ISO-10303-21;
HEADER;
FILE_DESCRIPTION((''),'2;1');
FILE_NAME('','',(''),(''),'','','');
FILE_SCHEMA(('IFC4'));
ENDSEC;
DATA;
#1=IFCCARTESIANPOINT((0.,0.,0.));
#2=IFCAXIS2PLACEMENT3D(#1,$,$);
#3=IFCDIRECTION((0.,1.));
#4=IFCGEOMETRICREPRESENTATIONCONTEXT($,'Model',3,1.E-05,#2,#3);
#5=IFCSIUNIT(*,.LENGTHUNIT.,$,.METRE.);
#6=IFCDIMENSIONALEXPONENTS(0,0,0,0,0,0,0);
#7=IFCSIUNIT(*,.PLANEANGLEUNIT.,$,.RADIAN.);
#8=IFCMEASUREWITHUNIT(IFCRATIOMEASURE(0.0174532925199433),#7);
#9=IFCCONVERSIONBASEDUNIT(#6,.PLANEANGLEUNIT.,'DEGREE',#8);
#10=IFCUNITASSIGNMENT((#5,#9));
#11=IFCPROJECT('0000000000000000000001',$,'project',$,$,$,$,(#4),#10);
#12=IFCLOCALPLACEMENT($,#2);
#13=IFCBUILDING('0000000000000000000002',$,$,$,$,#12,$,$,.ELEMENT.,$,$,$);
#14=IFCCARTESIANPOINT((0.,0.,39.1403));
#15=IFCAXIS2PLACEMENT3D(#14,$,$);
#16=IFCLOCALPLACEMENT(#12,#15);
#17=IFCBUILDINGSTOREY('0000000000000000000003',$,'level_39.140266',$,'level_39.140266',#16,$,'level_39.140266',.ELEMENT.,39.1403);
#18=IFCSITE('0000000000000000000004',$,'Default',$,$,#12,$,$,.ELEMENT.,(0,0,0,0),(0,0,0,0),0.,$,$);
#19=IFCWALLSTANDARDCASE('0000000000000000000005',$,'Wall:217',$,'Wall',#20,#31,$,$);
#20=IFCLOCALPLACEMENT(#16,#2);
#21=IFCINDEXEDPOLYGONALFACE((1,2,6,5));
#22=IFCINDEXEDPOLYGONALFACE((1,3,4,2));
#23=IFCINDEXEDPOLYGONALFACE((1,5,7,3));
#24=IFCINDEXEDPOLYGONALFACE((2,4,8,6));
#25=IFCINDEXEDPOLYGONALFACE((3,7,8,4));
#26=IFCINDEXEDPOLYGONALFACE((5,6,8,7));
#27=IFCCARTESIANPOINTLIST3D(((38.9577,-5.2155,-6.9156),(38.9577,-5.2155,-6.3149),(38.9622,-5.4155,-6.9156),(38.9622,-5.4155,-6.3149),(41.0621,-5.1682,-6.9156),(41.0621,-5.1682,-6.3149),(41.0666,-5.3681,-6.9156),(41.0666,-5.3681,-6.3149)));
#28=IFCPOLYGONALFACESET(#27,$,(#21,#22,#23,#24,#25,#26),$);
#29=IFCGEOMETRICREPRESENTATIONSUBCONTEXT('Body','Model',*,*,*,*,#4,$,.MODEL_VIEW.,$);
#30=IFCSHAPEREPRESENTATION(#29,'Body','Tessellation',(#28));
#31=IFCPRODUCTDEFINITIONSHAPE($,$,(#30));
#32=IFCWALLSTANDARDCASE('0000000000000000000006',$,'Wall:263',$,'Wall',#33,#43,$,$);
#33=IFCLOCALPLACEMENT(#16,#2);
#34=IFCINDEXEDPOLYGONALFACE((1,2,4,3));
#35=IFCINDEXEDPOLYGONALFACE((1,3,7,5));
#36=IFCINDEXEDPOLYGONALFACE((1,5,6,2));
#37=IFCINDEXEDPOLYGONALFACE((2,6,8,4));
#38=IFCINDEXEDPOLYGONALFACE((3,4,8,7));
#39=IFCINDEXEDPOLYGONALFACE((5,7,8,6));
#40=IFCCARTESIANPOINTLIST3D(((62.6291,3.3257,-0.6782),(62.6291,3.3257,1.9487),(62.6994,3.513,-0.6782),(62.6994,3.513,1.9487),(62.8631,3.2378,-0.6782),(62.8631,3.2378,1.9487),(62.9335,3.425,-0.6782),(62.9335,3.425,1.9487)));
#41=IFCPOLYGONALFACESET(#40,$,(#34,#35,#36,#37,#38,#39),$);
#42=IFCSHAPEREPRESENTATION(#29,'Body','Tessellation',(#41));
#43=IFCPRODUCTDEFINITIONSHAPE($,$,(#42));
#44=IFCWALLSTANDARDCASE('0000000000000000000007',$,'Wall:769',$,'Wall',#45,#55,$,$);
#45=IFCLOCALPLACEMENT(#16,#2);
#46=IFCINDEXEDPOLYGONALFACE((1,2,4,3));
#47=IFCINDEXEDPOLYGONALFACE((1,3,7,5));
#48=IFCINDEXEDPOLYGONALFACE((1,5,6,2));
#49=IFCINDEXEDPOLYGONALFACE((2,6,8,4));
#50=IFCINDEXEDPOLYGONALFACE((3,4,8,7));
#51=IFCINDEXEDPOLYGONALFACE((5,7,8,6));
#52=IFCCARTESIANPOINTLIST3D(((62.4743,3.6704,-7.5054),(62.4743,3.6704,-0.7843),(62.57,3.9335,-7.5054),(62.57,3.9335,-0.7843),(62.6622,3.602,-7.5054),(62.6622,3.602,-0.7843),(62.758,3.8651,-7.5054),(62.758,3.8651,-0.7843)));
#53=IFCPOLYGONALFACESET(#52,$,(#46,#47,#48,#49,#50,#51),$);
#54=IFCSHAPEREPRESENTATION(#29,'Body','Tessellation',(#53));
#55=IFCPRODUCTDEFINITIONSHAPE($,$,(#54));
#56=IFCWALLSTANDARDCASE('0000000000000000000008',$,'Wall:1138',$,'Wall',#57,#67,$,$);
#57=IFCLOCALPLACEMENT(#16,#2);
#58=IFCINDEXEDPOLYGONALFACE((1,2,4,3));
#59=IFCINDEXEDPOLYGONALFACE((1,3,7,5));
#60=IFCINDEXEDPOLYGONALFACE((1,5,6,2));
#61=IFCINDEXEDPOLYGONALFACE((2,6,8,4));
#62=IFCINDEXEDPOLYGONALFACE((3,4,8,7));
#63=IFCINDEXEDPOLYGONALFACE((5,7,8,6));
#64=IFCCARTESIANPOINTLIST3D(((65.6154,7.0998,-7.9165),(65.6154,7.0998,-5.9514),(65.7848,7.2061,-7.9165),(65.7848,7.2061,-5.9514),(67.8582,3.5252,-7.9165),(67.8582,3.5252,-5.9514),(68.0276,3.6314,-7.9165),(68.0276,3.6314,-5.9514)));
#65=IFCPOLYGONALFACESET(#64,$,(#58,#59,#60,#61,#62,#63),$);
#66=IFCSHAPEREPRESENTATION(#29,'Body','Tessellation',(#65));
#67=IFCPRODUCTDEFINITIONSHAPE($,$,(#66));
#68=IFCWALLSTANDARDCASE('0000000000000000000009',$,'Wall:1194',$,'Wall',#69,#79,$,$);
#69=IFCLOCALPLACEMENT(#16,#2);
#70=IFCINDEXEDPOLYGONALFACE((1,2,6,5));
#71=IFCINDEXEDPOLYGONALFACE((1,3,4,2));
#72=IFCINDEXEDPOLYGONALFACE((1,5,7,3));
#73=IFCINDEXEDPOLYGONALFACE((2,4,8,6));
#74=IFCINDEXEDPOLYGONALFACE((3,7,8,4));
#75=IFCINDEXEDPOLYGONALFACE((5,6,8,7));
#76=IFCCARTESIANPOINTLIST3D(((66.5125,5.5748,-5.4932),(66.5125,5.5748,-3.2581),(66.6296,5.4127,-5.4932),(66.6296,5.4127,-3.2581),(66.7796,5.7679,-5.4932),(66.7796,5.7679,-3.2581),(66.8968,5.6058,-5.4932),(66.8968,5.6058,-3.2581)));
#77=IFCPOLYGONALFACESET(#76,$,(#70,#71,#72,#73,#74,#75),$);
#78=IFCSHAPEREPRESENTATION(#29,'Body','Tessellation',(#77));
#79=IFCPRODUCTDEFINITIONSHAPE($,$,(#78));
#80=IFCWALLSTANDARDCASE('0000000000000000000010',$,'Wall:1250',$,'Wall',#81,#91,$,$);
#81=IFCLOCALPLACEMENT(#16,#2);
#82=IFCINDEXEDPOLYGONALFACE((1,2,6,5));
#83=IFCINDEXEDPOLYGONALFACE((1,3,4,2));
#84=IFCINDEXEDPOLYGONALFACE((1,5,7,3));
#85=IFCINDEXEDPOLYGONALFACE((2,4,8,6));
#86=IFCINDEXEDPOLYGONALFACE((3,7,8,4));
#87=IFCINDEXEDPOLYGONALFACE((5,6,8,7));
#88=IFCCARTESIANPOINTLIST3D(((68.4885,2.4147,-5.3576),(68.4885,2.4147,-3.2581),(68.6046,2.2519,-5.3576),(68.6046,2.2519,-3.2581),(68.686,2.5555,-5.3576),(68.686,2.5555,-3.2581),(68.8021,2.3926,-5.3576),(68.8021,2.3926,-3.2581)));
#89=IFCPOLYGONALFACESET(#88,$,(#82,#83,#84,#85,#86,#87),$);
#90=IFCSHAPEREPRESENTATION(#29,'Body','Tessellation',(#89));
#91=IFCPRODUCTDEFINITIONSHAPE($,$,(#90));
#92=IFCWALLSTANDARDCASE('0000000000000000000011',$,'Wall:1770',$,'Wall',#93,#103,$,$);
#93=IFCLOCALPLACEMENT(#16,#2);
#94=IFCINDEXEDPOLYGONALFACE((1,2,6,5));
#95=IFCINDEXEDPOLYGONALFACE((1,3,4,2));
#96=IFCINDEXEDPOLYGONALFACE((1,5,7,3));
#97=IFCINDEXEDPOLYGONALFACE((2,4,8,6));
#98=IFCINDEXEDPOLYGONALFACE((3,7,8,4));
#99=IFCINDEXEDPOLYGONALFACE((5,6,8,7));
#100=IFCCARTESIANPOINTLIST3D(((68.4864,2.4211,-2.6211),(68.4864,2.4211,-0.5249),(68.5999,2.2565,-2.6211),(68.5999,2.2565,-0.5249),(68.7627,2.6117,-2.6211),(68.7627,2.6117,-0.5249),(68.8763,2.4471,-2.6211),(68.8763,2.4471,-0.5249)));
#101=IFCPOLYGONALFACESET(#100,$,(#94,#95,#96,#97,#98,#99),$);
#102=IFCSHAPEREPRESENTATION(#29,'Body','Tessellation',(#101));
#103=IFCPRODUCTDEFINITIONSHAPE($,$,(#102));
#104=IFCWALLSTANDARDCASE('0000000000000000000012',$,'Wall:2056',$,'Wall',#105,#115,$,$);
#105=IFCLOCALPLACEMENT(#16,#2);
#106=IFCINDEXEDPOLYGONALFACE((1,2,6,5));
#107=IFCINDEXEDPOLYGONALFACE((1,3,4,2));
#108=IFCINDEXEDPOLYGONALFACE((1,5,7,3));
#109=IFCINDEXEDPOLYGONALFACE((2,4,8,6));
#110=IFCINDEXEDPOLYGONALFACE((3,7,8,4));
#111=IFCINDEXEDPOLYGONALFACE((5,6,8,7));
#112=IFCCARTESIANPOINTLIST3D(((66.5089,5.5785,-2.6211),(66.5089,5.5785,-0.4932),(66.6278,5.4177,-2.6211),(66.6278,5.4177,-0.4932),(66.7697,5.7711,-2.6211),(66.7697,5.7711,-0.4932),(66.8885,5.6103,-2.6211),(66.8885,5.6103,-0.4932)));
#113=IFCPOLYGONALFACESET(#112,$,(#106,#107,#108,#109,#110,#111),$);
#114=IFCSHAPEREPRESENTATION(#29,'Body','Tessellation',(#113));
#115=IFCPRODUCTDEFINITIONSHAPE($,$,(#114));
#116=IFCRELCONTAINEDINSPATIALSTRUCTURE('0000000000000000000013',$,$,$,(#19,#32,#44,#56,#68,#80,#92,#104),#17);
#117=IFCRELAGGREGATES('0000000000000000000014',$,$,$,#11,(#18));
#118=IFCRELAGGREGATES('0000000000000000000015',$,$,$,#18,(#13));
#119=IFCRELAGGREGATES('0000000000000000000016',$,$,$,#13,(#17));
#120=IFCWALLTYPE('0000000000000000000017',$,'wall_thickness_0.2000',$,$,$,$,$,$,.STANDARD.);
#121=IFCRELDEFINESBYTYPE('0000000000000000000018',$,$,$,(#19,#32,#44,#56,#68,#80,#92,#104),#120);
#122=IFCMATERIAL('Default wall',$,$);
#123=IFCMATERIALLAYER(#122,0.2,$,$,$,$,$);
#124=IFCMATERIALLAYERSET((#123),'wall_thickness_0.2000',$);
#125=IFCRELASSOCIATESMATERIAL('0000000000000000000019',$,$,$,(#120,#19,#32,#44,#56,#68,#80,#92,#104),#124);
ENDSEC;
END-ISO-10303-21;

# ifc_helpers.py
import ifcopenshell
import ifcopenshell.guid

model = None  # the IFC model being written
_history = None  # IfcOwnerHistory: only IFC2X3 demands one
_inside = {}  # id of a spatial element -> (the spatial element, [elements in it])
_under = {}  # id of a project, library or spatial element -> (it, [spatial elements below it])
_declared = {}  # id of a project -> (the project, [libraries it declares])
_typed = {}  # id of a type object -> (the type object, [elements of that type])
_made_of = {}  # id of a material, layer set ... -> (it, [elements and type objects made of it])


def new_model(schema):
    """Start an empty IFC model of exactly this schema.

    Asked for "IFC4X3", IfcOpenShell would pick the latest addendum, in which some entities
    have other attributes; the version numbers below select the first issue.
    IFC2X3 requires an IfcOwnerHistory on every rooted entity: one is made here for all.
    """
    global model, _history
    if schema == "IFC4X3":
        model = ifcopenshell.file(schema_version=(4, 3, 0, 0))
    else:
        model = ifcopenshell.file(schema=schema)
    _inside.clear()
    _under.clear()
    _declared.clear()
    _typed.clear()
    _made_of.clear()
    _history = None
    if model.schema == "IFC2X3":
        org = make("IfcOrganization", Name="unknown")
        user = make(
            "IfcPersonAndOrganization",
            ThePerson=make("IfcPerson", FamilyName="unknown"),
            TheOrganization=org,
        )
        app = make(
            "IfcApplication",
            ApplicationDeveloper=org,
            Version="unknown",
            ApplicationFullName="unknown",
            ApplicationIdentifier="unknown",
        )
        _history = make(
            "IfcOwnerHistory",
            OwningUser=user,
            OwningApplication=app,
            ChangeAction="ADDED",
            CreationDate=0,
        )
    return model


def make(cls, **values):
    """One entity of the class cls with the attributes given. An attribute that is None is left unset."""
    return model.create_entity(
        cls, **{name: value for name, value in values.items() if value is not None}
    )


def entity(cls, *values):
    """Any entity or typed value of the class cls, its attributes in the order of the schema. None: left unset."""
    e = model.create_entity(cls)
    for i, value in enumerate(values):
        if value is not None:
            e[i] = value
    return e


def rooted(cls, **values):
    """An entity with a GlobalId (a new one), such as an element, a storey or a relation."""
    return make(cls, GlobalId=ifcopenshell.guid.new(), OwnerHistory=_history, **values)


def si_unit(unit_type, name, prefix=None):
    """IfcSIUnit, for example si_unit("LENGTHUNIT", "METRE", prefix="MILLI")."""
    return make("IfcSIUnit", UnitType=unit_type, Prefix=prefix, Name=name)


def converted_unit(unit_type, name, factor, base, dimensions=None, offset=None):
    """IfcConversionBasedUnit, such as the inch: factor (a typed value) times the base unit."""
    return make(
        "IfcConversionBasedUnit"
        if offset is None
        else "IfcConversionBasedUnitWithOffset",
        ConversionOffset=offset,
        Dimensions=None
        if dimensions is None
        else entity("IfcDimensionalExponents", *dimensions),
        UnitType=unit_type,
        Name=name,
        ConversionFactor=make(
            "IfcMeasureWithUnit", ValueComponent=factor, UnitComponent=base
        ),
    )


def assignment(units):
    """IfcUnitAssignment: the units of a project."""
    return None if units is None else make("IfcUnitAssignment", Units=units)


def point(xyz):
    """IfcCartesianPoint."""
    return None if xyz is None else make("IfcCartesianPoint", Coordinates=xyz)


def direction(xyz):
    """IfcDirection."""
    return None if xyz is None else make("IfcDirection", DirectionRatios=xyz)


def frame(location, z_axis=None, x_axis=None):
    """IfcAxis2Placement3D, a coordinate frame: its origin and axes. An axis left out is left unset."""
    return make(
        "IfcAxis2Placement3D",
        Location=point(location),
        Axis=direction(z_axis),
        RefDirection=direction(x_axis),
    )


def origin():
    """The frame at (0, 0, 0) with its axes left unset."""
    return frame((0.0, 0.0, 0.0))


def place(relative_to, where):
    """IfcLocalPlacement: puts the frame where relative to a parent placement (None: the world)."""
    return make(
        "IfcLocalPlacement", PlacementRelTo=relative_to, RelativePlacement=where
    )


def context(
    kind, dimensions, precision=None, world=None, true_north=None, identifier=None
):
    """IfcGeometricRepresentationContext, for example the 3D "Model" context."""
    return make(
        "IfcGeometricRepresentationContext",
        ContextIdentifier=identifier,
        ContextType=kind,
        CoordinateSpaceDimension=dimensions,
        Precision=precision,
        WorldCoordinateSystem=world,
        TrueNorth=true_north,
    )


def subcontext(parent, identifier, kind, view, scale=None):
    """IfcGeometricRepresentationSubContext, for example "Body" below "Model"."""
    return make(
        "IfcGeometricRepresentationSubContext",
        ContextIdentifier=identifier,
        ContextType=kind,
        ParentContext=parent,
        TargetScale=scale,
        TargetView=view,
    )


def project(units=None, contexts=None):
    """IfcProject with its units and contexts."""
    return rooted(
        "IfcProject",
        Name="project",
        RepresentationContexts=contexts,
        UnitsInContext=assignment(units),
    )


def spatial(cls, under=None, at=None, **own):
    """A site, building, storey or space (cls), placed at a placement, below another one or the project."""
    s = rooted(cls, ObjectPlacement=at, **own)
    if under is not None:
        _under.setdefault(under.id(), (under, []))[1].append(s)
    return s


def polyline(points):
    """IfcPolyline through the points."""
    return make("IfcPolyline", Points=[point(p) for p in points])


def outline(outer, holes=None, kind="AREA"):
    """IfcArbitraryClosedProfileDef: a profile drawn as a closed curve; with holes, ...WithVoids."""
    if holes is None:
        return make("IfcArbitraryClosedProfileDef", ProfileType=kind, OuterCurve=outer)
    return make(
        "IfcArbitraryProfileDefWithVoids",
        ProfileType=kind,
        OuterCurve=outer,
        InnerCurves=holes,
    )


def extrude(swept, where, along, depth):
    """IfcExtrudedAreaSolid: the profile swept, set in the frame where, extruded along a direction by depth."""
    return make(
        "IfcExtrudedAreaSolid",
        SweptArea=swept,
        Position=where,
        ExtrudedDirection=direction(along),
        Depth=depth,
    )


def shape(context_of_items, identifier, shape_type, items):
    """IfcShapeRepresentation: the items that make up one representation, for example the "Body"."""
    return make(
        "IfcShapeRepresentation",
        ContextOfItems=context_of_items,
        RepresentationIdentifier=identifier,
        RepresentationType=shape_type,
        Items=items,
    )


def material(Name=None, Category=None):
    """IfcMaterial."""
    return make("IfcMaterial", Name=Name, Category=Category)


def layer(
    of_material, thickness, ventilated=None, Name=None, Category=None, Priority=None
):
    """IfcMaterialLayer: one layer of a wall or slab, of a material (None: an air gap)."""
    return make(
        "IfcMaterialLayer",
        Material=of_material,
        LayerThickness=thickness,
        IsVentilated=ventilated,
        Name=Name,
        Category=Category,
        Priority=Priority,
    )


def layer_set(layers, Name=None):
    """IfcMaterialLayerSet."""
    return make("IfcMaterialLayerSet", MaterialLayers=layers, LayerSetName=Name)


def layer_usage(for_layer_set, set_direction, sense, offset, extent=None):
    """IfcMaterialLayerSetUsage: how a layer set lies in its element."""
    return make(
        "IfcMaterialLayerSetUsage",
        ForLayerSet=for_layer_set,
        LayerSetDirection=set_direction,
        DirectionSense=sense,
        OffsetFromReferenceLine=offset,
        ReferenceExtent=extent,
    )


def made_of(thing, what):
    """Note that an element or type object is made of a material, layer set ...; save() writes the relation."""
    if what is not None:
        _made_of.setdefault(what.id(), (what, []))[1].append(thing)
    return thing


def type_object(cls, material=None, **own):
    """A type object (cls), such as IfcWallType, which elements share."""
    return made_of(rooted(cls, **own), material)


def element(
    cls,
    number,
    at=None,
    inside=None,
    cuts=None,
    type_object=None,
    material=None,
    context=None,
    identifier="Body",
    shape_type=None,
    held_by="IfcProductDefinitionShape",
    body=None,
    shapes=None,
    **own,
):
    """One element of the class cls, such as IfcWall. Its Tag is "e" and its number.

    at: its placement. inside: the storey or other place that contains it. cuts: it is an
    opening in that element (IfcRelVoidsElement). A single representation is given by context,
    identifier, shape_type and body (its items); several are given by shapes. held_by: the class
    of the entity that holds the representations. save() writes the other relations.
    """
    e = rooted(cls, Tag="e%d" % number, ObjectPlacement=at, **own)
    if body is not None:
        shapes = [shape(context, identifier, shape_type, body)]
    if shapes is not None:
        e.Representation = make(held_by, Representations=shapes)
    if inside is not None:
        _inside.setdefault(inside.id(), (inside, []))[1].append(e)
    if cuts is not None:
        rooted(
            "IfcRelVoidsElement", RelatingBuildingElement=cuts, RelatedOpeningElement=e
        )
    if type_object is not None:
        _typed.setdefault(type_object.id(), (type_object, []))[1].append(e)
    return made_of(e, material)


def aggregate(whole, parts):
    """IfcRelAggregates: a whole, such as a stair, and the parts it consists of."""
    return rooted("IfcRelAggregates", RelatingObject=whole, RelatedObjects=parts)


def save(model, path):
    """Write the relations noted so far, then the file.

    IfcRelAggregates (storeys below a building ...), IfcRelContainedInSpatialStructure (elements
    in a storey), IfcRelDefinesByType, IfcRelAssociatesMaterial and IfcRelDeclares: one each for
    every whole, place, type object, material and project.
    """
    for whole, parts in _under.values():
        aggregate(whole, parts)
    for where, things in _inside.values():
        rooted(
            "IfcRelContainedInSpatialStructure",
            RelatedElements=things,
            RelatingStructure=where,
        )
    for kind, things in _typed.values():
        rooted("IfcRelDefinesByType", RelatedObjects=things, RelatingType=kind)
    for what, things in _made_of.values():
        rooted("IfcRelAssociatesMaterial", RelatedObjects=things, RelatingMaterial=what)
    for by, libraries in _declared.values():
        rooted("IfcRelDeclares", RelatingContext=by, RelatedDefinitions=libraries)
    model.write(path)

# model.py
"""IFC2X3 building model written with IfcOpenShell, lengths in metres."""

from ifc_helpers import new_model, entity, si_unit, converted_unit, direction, frame, origin, place, context, subcontext, project, spatial, polyline, outline, extrude, material, layer, layer_set, layer_usage, type_object, element, save


model = new_model("IFC2X3")

# Units and contexts
model_context = context("Model", 3, precision=1e-05, world=origin(), true_north=direction((0.0, 1.0)))
body_context = subcontext(model_context, "Body", "Model", "MODEL_VIEW")
ifc_project = project(units=[si_unit("LENGTHUNIT", "METRE"), converted_unit("PLANEANGLEUNIT", "DEGREE", entity("IfcRatioMeasure", 0.0174532925199433), si_unit("PLANEANGLEUNIT", "RADIAN"), dimensions=[0, 0, 0, 0, 0, 0, 0])], contexts=[model_context])

# Site, building, storey
placement_1 = place(None, origin())
site = spatial("IfcSite", under=ifc_project, at=placement_1, Name="Default", CompositionType="ELEMENT", RefLatitude=(0, 0, 0, 0), RefLongitude=(0, 0, 0, 0), RefElevation=0.0)
building = spatial("IfcBuilding", under=site, at=placement_1, CompositionType="ELEMENT")
storey_placement = place(placement_1, frame((0.0, 0.0, 39.1403)))
storey = spatial("IfcBuildingStorey", under=building, at=storey_placement, Name="level_39.140266", ObjectType="level_39.140266", LongName="level_39.140266", CompositionType="ELEMENT", Elevation=39.1403)

# Walls
ifc_material_1 = material(Name="Default wall")
ifc_layer = layer(ifc_material_1, 0.2)
ifc_layer_set = layer_set([ifc_layer], Name="wall_thickness_0.2000")
ifc_layer_usage = layer_usage(ifc_layer_set, "AXIS2", "POSITIVE", -0.1)
wall_type = type_object("IfcWallType", Name="wall_thickness_0.2000", PredefinedType="STANDARD", material=ifc_layer_set)
placement_2 = place(placement_1, frame((0.0, 0.0, 32.2247)))
wall_1_placement = place(placement_2, frame((38.9599, -5.3155, 0.0), z_axis=(0.0, 0.0, 1.0), x_axis=(0.999747, 0.022476, 0.0)))
element("IfcWallStandardCase", 1, at=wall_1_placement, inside=storey, type_object=wall_type, material=ifc_layer_usage, Name="Wall:217", ObjectType="Wall", context=body_context, shape_type="SweptSolid", body=[
    extrude(outline(polyline([(2.105, -0.1), (2.105, 0.1), (0.0, 0.1), (0.0, -0.1), (2.105, -0.1)])), origin(), (0.0, 0.0, 1.0), 0.6007),
])
placement_3 = place(placement_1, frame((0.0, 0.0, 38.4621)))
wall_2_placement = place(placement_3, frame((62.8983, 3.3314, 0.0), z_axis=(0.0, 0.0, 1.0), x_axis=(-0.936119, 0.351683, 0.0)))
element("IfcWallStandardCase", 2, at=wall_2_placement, inside=storey, type_object=wall_type, material=ifc_layer_usage, Name="Wall:263", ObjectType="Wall", context=body_context, shape_type="SweptSolid", body=[
    extrude(outline(polyline([(0.25, -0.1), (0.25, 0.1), (0.0, 0.1), (0.0, -0.1), (0.25, -0.1)])), origin(), (0.0, 0.0, 1.0), 2.6269),
])
placement_4 = place(placement_1, frame((0.0, 0.0, 31.6349)))
wall_3_placement = place(placement_4, frame((62.664, 3.8993, 0.0), z_axis=(0.0, 0.0, 1.0), x_axis=(-0.341987, -0.939705, 0.0)))
element("IfcWallStandardCase", 3, at=wall_3_placement, inside=storey, type_object=wall_type, material=ifc_layer_usage, Name="Wall:769", ObjectType="Wall", context=body_context, shape_type="SweptSolid", body=[
    extrude(outline(polyline([(0.28, -0.1), (0.28, 0.1), (0.0, 0.1), (0.0, -0.1), (0.28, -0.1)])), origin(), (0.0, 0.0, 1.0), 6.7211),
])
placement_5 = place(placement_1, frame((0.0, 0.0, 31.2238)))
wall_4_placement = place(placement_5, frame((65.7001, 7.153, 0.0), z_axis=(0.0, 0.0, 1.0), x_axis=(0.531473, -0.847075, 0.0)))
element("IfcWallStandardCase", 4, at=wall_4_placement, inside=storey, type_object=wall_type, material=ifc_layer_usage, Name="Wall:1138", ObjectType="Wall", context=body_context, shape_type="SweptSolid", body=[
    extrude(outline(polyline([(4.22, -0.1), (4.22, 0.1), (0.0, 0.1), (0.0, -0.1), (4.22, -0.1)])), origin(), (0.0, 0.0, 1.0), 1.9651),
])
placement_6 = place(placement_1, frame((0.0, 0.0, 33.6471)))
wall_5_placement = place(placement_6, frame((66.8382, 5.6869, 0.0), z_axis=(0.0, 0.0, 1.0), x_axis=(-0.810408, -0.585866, 0.0)))
element("IfcWallStandardCase", 5, at=wall_5_placement, inside=storey, type_object=wall_type, material=ifc_layer_usage, Name="Wall:1194", ObjectType="Wall", context=body_context, shape_type="SweptSolid", body=[
    extrude(outline(polyline([(0.3296, -0.1), (0.3296, 0.1), (0.0, 0.1), (0.0, -0.1), (0.3296, -0.1)])), origin(), (0.0, 0.0, 1.0), 2.2351),
])
placement_7 = place(placement_1, frame((0.0, 0.0, 33.7827)))
wall_6_placement = place(placement_7, frame((68.7441, 2.474, 0.0), z_axis=(0.0, 0.0, 1.0), x_axis=(-0.814408, -0.580292, 0.0)))
element("IfcWallStandardCase", 6, at=wall_6_placement, inside=storey, type_object=wall_type, material=ifc_layer_usage, Name="Wall:1250", ObjectType="Wall", context=body_context, shape_type="SweptSolid", body=[
    extrude(outline(polyline([(0.2425, -0.1), (0.2425, 0.1), (0.0, 0.1), (0.0, -0.1), (0.2425, -0.1)])), origin(), (0.0, 0.0, 1.0), 2.0995),
])

# Walls
placement_8 = place(placement_1, frame((0.0, 0.0, 36.5192)))
wall_7_placement = place(placement_8, frame((68.8195, 2.5294, 0.0), z_axis=(0.0, 0.0, 1.0), x_axis=(-0.823211, -0.567736, 0.0)))
element("IfcWallStandardCase", 7, at=wall_7_placement, inside=storey, type_object=wall_type, material=ifc_layer_usage, Name="Wall:1770", ObjectType="Wall", context=body_context, shape_type="SweptSolid", body=[
    extrude(outline(polyline([(0.3357, -0.1), (0.3357, 0.1), (0.0, 0.1), (0.0, -0.1), (0.3357, -0.1)])), origin(), (0.0, 0.0, 1.0), 2.0962),
])
placement_9 = place(placement_1, frame((0.0, 0.0, 36.5192)))
wall_8_placement = place(placement_9, frame((66.8291, 5.6907, 0.0), z_axis=(0.0, 0.0, 1.0), x_axis=(-0.804347, -0.594159, 0.0)))
element("IfcWallStandardCase", 8, at=wall_8_placement, inside=storey, type_object=wall_type, material=ifc_layer_usage, Name="Wall:2056", ObjectType="Wall", context=body_context, shape_type="SweptSolid", body=[
    extrude(outline(polyline([(0.3242, -0.1), (0.3242, 0.1), (0.0, 0.1), (0.0, -0.1), (0.3242, -0.1)])), origin(), (0.0, 0.0, 1.0), 2.1279),
])

save(model, "model.ifc")
